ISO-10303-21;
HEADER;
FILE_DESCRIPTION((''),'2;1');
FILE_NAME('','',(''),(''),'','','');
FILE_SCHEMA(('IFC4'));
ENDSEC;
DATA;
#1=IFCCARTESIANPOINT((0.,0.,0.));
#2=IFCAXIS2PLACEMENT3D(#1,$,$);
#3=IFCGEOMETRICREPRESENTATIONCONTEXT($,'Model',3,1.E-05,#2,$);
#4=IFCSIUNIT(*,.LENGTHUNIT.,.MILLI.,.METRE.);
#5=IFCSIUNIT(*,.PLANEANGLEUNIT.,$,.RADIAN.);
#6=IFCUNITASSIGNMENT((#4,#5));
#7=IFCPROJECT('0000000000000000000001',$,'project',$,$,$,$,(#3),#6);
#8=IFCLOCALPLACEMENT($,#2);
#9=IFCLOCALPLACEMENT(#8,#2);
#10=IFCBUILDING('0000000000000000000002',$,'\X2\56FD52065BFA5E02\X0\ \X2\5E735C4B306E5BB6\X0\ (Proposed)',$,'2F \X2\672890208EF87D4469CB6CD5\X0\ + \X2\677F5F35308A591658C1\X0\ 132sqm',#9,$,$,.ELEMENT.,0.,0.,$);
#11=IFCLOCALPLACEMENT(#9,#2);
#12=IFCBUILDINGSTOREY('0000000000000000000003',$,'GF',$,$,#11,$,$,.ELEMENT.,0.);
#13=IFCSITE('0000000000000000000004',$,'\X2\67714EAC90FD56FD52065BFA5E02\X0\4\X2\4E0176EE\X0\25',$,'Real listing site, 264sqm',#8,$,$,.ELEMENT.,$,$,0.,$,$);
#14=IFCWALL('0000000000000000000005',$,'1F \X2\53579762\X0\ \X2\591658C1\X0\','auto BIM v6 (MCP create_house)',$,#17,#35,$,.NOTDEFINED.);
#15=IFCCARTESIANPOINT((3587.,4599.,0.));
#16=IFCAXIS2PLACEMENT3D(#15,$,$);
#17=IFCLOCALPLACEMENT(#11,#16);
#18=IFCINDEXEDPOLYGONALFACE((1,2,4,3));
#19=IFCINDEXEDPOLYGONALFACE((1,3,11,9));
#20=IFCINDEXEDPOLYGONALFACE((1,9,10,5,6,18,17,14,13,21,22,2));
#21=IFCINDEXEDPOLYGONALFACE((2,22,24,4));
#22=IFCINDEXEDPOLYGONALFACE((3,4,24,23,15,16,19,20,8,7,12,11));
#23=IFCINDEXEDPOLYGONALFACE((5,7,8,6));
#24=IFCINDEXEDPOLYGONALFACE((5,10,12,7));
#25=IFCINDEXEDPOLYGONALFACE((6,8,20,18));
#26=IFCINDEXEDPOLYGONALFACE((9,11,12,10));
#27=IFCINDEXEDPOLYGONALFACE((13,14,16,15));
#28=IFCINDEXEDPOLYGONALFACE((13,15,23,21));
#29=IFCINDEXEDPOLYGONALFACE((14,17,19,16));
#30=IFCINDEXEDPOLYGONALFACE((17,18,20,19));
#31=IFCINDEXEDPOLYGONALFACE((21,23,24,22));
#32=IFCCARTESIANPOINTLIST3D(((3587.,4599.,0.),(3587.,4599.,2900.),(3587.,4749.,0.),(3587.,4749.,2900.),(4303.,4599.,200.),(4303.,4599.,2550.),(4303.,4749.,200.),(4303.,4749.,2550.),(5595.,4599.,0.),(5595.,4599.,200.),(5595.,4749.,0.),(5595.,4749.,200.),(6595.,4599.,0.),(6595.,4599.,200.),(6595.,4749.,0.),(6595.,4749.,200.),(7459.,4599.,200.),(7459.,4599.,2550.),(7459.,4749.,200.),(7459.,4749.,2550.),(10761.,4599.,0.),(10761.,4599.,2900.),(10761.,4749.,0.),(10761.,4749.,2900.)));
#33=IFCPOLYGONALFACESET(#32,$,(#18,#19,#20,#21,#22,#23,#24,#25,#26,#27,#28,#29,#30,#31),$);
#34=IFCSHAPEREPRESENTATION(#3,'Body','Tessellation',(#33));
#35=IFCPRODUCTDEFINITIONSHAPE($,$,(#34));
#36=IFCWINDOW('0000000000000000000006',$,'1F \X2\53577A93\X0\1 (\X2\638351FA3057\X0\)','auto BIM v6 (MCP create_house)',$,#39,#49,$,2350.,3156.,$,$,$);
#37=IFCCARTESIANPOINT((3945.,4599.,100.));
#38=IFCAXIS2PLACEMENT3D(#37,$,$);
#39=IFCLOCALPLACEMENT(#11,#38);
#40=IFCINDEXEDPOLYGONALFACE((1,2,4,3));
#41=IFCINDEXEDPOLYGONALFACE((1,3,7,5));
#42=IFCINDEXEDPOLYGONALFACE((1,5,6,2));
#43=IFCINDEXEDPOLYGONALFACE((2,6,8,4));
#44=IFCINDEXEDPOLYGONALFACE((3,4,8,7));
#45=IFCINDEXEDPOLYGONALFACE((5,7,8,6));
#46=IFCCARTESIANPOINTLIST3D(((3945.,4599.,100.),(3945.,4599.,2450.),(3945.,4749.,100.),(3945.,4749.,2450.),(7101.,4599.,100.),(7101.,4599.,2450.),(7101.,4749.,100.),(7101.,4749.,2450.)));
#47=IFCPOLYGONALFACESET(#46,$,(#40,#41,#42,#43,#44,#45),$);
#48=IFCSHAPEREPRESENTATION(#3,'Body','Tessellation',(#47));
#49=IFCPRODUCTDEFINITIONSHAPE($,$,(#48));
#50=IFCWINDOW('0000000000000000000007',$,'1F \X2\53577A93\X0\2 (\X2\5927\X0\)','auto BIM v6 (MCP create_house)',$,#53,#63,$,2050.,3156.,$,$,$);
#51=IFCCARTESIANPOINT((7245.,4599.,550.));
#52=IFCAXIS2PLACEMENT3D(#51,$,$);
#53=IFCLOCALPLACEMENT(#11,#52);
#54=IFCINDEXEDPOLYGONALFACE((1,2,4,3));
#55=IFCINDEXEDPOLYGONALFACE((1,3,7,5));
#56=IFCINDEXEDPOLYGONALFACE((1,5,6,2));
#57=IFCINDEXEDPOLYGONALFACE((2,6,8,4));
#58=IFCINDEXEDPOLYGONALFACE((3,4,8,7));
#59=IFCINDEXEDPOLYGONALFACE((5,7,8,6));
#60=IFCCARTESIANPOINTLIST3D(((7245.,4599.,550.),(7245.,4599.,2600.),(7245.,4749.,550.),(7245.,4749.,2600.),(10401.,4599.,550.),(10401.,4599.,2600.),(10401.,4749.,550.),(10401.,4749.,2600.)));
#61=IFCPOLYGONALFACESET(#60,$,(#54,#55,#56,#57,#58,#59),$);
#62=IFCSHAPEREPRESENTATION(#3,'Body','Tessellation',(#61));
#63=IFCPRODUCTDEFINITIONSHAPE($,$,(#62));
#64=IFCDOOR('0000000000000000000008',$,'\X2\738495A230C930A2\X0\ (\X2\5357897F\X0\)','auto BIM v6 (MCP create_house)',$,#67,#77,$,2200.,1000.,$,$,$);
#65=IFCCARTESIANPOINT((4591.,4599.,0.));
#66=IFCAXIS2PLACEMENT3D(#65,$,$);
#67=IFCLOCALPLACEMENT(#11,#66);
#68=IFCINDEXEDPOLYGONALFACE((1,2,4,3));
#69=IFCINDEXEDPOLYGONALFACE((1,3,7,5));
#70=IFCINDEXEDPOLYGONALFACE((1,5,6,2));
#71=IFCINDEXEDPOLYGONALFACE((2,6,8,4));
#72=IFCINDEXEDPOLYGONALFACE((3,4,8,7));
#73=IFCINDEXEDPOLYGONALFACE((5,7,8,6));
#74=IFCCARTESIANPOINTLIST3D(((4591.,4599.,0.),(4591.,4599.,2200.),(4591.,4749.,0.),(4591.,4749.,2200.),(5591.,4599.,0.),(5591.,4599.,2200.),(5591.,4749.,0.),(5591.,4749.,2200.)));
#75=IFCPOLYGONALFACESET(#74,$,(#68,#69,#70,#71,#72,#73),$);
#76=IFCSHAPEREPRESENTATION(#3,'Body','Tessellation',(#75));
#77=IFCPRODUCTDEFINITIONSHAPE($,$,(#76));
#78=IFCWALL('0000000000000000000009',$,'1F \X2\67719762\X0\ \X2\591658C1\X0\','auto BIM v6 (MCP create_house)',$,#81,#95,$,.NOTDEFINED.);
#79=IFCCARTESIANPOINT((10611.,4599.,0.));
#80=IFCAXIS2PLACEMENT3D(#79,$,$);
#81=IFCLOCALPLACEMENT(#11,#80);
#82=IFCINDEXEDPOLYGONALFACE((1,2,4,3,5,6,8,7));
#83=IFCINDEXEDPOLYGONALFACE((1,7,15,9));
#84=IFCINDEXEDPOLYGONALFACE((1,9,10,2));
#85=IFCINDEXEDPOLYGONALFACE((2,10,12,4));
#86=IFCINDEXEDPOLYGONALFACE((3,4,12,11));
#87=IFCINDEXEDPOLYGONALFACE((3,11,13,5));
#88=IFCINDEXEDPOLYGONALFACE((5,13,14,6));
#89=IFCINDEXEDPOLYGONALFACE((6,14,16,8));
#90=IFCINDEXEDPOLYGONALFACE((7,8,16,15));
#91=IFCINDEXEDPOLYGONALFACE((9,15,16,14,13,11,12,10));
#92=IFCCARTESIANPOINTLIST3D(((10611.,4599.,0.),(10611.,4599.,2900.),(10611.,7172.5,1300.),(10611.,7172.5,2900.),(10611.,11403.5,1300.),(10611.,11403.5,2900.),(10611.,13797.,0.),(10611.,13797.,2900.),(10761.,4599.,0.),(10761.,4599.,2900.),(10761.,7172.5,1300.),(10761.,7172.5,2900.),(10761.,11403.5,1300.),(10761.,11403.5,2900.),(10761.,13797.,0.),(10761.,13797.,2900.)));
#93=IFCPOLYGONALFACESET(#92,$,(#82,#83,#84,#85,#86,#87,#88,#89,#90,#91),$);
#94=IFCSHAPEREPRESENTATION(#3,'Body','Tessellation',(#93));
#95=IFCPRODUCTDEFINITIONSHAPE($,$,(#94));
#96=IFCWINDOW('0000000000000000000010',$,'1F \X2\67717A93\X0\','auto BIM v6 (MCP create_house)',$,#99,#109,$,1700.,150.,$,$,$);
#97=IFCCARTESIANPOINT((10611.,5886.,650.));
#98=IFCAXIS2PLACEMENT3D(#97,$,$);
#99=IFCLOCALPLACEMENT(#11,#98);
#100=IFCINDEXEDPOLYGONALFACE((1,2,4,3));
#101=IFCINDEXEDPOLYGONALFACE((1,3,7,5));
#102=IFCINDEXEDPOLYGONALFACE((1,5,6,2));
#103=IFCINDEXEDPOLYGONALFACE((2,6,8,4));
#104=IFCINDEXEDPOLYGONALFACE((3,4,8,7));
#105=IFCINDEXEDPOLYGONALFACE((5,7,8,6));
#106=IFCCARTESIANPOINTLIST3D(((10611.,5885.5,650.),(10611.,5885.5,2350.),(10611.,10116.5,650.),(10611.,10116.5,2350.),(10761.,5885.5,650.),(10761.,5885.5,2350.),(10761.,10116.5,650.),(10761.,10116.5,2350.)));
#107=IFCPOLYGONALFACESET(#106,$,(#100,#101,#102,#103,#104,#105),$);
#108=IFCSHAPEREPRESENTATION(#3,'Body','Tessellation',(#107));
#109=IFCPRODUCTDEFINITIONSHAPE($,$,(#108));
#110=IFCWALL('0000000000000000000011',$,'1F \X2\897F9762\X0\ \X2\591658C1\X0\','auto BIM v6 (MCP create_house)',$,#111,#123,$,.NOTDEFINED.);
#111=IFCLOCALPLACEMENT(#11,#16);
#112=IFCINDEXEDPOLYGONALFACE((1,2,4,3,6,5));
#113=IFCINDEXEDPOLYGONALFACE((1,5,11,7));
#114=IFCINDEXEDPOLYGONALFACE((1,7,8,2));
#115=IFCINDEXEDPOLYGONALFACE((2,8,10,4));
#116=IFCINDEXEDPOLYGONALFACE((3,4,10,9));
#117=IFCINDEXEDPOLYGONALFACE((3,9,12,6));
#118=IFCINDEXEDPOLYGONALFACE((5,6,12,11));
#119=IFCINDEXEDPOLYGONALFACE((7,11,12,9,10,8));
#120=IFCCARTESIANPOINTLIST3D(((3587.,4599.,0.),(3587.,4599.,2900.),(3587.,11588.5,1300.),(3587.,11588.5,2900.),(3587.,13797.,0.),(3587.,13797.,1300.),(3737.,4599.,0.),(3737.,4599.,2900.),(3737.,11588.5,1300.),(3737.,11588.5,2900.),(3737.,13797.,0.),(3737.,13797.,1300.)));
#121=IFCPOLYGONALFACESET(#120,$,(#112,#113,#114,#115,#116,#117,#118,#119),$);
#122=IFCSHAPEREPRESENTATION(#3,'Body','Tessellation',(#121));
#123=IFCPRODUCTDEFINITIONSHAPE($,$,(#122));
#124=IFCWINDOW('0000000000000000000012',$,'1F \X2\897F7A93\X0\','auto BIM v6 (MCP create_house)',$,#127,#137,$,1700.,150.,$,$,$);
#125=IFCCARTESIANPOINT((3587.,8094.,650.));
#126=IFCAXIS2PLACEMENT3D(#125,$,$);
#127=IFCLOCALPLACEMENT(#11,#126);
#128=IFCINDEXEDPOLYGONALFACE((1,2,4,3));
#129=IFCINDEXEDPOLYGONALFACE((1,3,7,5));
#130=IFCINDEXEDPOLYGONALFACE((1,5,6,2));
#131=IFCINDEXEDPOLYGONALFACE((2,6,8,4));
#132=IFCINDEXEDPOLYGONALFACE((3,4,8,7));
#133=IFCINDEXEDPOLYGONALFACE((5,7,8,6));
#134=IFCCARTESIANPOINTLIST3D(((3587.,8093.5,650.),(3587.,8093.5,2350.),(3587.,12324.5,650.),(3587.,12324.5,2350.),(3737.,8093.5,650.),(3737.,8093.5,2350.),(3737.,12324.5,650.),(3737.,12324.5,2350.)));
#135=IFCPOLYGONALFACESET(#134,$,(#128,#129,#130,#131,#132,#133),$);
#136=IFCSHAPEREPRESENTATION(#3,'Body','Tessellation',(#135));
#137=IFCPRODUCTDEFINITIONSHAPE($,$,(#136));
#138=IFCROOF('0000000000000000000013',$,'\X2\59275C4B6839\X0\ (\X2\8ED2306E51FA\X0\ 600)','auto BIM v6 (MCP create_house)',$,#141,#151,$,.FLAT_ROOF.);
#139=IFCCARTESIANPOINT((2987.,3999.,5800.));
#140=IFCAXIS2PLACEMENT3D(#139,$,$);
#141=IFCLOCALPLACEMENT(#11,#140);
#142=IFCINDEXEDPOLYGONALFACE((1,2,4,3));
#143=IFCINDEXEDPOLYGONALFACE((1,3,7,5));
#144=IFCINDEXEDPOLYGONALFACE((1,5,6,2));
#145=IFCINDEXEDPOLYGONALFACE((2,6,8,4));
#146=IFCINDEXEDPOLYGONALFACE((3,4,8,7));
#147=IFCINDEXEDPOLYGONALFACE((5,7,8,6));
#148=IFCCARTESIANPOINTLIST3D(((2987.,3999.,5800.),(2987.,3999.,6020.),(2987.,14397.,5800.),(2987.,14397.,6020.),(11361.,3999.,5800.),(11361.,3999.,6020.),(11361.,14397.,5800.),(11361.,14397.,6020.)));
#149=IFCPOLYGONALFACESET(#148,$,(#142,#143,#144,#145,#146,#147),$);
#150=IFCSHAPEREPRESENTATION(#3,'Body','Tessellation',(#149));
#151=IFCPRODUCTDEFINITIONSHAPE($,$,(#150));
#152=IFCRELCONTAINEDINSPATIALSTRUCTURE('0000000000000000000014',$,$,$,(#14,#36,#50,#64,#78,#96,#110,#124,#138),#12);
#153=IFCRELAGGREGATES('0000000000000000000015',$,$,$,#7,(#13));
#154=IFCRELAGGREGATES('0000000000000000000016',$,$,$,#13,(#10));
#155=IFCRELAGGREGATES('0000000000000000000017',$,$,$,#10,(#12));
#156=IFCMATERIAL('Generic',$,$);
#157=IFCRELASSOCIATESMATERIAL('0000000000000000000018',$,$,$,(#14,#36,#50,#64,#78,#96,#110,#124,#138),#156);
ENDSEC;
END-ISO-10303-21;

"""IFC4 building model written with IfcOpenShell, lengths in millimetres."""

from ifc_helpers import new_model, si_unit, frame, frame_2d, origin, place, context, project, spatial, rectangle, extrude, material, element, fill, save


model = new_model("IFC4")

# Units and contexts
model_context = context("Model", 3, precision=1e-05, world=origin())
ifc_project = project(units=[si_unit("LENGTHUNIT", "METRE", prefix="MILLI"), si_unit("PLANEANGLEUNIT", "RADIAN")], contexts=[model_context])

# Site, building, storey
site_placement = place(None, origin())
site = spatial("IfcSite", under=ifc_project, at=site_placement, Name="東京都国分寺市4丁目25", ObjectType="Real listing site, 264sqm", CompositionType="ELEMENT", RefElevation=0.0)
building_placement = place(site_placement, origin())
building = spatial("IfcBuilding", under=site, at=building_placement, Name="国分寺市 平屋の家 (Proposed)", ObjectType="2F 木造軸組構法 + 板張り外壁 132sqm", CompositionType="ELEMENT", ElevationOfRefHeight=0.0, ElevationOfTerrain=0.0)
storey_placement = place(building_placement, origin())
storey = spatial("IfcBuildingStorey", under=building, at=storey_placement, Name="GF", CompositionType="ELEMENT", Elevation=0.0)

# Shared definitions
ifc_material = material(Name="Generic")

# Wall, openings, windows, door
wall_1_placement = place(storey_placement, frame((3587.0, 4599.0, 0.0)))
wall_1 = element("IfcWall", 1, at=wall_1_placement, inside=storey, material=ifc_material, Name="1F 南面 外壁", Description="auto BIM v6 (MCP create_house)", PredefinedType="NOTDEFINED", context=model_context, shape_type="SweptSolid", body=[
    extrude(rectangle(XDim=7174.0, YDim=150.0, at=frame_2d((3587.0, 75.0))), frame((3587.0, 4599.0, 0.0)), (0.0, 0.0, 1.0), 2900.0),
])
opening_1_placement = place(storey_placement, frame((3945.0, 4599.0, 100.0)))
opening_1 = element("IfcOpeningElement", 2, at=opening_1_placement, cuts=wall_1, PredefinedType="NOTDEFINED", context=model_context, shape_type="SweptSolid", body=[
    extrude(rectangle(XDim=3156.0, YDim=150.0, at=frame_2d((1578.0, 75.0))), frame((3945.0, 4599.0, 100.0)), (0.0, 0.0, 1.0), 2350.0),
])
opening_2_placement = place(storey_placement, frame((7245.0, 4599.0, 550.0)))
opening_2 = element("IfcOpeningElement", 3, at=opening_2_placement, cuts=wall_1, PredefinedType="NOTDEFINED", context=model_context, shape_type="SweptSolid", body=[
    extrude(rectangle(XDim=3156.0, YDim=150.0, at=frame_2d((1578.0, 75.0))), frame((7245.0, 4599.0, 550.0)), (0.0, 0.0, 1.0), 2050.0),
])
opening_3_placement = place(storey_placement, frame((4591.0, 4599.0, 0.0)))
opening_3 = element("IfcOpeningElement", 4, at=opening_3_placement, cuts=wall_1, PredefinedType="NOTDEFINED", context=model_context, shape_type="SweptSolid", body=[
    extrude(rectangle(XDim=1000.0, YDim=150.0, at=frame_2d((500.0, 75.0))), frame((4591.0, 4599.0, 0.0)), (0.0, 0.0, 1.0), 2200.0),
])
window_1_placement = place(storey_placement, frame((3945.0, 4599.0, 100.0)))
window_1 = element("IfcWindow", 5, at=window_1_placement, inside=storey, material=ifc_material, Name="1F 南窓1 (掃出し)", Description="auto BIM v6 (MCP create_house)", OverallHeight=2350.0, OverallWidth=3156.0, context=model_context, shape_type="SweptSolid", body=[
    extrude(rectangle(XDim=3156.0, YDim=150.0, at=frame_2d((1578.0, 75.0))), frame((3945.0, 4599.0, 100.0)), (0.0, 0.0, 1.0), 2350.0),
])
fill(opening_1, window_1)
window_2_placement = place(storey_placement, frame((7245.0, 4599.0, 550.0)))
window_2 = element("IfcWindow", 6, at=window_2_placement, inside=storey, material=ifc_material, Name="1F 南窓2 (大)", Description="auto BIM v6 (MCP create_house)", OverallHeight=2050.0, OverallWidth=3156.0, context=model_context, shape_type="SweptSolid", body=[
    extrude(rectangle(XDim=3156.0, YDim=150.0, at=frame_2d((1578.0, 75.0))), frame((7245.0, 4599.0, 550.0)), (0.0, 0.0, 1.0), 2050.0),
])
fill(opening_2, window_2)
door_placement = place(storey_placement, frame((4591.0, 4599.0, 0.0)))
door = element("IfcDoor", 7, at=door_placement, inside=storey, material=ifc_material, Name="玄関ドア (南西)", Description="auto BIM v6 (MCP create_house)", OverallHeight=2200.0, OverallWidth=1000.0, context=model_context, shape_type="SweptSolid", body=[
    extrude(rectangle(XDim=1000.0, YDim=150.0, at=frame_2d((500.0, 75.0))), frame((4591.0, 4599.0, 0.0)), (0.0, 0.0, 1.0), 2200.0),
])
fill(opening_3, door)

# Walls, openings, windows
wall_2_placement = place(storey_placement, frame((10611.0, 4599.0, 0.0)))
wall_2 = element("IfcWall", 8, at=wall_2_placement, inside=storey, material=ifc_material, Name="1F 東面 外壁", Description="auto BIM v6 (MCP create_house)", PredefinedType="NOTDEFINED", context=model_context, shape_type="SweptSolid", body=[
    extrude(rectangle(XDim=150.0, YDim=9198.0, at=frame_2d((75.0, 4599.0))), frame((10611.0, 4599.0, 0.0)), (0.0, 0.0, 1.0), 2900.0),
])
opening_4_placement = place(storey_placement, frame((10611.0, 5886.0, 650.0)))
opening_4 = element("IfcOpeningElement", 9, at=opening_4_placement, cuts=wall_2, PredefinedType="NOTDEFINED", context=model_context, shape_type="SweptSolid", body=[
    extrude(rectangle(XDim=150.0, YDim=4231.0, at=frame_2d((75.0, 2115.0))), frame((10611.0, 5886.0, 650.0)), (0.0, 0.0, 1.0), 1700.0),
])
window_3_placement = place(storey_placement, frame((10611.0, 5886.0, 650.0)))
window_3 = element("IfcWindow", 10, at=window_3_placement, inside=storey, material=ifc_material, Name="1F 東窓", Description="auto BIM v6 (MCP create_house)", OverallHeight=1700.0, OverallWidth=150.0, context=model_context, shape_type="SweptSolid", body=[
    extrude(rectangle(XDim=150.0, YDim=4231.0, at=frame_2d((75.0, 2115.0))), frame((10611.0, 5886.0, 650.0)), (0.0, 0.0, 1.0), 1700.0),
])
fill(opening_4, window_3)
wall_3_placement = place(storey_placement, frame((3587.0, 4599.0, 0.0)))
wall_3 = element("IfcWall", 11, at=wall_3_placement, inside=storey, material=ifc_material, Name="1F 西面 外壁", Description="auto BIM v6 (MCP create_house)", PredefinedType="NOTDEFINED", context=model_context, shape_type="SweptSolid", body=[
    extrude(rectangle(XDim=150.0, YDim=9198.0, at=frame_2d((75.0, 4599.0))), frame((3587.0, 4599.0, 0.0)), (0.0, 0.0, 1.0), 2900.0),
])
opening_5_placement = place(storey_placement, frame((3587.0, 8094.0, 650.0)))
opening_5 = element("IfcOpeningElement", 12, at=opening_5_placement, cuts=wall_3, PredefinedType="NOTDEFINED", context=model_context, shape_type="SweptSolid", body=[
    extrude(rectangle(XDim=150.0, YDim=4231.0, at=frame_2d((75.0, 2115.0))), frame((3587.0, 8094.0, 650.0)), (0.0, 0.0, 1.0), 1700.0),
])
window_4_placement = place(storey_placement, frame((3587.0, 8094.0, 650.0)))
window_4 = element("IfcWindow", 13, at=window_4_placement, inside=storey, material=ifc_material, Name="1F 西窓", Description="auto BIM v6 (MCP create_house)", OverallHeight=1700.0, OverallWidth=150.0, context=model_context, shape_type="SweptSolid", body=[
    extrude(rectangle(XDim=150.0, YDim=4231.0, at=frame_2d((75.0, 2115.0))), frame((3587.0, 8094.0, 650.0)), (0.0, 0.0, 1.0), 1700.0),
])
fill(opening_5, window_4)

# Roof
roof_placement = place(storey_placement, frame((2987.0, 3999.0, 5800.0)))
element("IfcRoof", 14, at=roof_placement, inside=storey, material=ifc_material, Name="大屋根 (軒の出 600)", Description="auto BIM v6 (MCP create_house)", PredefinedType="FLAT_ROOF", context=model_context, shape_type="SweptSolid", body=[
    extrude(rectangle(XDim=8374.0, YDim=10398.0, at=frame_2d((4187.0, 5199.0))), frame((2987.0, 3999.0, 5800.0)), (0.0, 0.0, 1.0), 220.0),
])

save(model, "model.ifc")
